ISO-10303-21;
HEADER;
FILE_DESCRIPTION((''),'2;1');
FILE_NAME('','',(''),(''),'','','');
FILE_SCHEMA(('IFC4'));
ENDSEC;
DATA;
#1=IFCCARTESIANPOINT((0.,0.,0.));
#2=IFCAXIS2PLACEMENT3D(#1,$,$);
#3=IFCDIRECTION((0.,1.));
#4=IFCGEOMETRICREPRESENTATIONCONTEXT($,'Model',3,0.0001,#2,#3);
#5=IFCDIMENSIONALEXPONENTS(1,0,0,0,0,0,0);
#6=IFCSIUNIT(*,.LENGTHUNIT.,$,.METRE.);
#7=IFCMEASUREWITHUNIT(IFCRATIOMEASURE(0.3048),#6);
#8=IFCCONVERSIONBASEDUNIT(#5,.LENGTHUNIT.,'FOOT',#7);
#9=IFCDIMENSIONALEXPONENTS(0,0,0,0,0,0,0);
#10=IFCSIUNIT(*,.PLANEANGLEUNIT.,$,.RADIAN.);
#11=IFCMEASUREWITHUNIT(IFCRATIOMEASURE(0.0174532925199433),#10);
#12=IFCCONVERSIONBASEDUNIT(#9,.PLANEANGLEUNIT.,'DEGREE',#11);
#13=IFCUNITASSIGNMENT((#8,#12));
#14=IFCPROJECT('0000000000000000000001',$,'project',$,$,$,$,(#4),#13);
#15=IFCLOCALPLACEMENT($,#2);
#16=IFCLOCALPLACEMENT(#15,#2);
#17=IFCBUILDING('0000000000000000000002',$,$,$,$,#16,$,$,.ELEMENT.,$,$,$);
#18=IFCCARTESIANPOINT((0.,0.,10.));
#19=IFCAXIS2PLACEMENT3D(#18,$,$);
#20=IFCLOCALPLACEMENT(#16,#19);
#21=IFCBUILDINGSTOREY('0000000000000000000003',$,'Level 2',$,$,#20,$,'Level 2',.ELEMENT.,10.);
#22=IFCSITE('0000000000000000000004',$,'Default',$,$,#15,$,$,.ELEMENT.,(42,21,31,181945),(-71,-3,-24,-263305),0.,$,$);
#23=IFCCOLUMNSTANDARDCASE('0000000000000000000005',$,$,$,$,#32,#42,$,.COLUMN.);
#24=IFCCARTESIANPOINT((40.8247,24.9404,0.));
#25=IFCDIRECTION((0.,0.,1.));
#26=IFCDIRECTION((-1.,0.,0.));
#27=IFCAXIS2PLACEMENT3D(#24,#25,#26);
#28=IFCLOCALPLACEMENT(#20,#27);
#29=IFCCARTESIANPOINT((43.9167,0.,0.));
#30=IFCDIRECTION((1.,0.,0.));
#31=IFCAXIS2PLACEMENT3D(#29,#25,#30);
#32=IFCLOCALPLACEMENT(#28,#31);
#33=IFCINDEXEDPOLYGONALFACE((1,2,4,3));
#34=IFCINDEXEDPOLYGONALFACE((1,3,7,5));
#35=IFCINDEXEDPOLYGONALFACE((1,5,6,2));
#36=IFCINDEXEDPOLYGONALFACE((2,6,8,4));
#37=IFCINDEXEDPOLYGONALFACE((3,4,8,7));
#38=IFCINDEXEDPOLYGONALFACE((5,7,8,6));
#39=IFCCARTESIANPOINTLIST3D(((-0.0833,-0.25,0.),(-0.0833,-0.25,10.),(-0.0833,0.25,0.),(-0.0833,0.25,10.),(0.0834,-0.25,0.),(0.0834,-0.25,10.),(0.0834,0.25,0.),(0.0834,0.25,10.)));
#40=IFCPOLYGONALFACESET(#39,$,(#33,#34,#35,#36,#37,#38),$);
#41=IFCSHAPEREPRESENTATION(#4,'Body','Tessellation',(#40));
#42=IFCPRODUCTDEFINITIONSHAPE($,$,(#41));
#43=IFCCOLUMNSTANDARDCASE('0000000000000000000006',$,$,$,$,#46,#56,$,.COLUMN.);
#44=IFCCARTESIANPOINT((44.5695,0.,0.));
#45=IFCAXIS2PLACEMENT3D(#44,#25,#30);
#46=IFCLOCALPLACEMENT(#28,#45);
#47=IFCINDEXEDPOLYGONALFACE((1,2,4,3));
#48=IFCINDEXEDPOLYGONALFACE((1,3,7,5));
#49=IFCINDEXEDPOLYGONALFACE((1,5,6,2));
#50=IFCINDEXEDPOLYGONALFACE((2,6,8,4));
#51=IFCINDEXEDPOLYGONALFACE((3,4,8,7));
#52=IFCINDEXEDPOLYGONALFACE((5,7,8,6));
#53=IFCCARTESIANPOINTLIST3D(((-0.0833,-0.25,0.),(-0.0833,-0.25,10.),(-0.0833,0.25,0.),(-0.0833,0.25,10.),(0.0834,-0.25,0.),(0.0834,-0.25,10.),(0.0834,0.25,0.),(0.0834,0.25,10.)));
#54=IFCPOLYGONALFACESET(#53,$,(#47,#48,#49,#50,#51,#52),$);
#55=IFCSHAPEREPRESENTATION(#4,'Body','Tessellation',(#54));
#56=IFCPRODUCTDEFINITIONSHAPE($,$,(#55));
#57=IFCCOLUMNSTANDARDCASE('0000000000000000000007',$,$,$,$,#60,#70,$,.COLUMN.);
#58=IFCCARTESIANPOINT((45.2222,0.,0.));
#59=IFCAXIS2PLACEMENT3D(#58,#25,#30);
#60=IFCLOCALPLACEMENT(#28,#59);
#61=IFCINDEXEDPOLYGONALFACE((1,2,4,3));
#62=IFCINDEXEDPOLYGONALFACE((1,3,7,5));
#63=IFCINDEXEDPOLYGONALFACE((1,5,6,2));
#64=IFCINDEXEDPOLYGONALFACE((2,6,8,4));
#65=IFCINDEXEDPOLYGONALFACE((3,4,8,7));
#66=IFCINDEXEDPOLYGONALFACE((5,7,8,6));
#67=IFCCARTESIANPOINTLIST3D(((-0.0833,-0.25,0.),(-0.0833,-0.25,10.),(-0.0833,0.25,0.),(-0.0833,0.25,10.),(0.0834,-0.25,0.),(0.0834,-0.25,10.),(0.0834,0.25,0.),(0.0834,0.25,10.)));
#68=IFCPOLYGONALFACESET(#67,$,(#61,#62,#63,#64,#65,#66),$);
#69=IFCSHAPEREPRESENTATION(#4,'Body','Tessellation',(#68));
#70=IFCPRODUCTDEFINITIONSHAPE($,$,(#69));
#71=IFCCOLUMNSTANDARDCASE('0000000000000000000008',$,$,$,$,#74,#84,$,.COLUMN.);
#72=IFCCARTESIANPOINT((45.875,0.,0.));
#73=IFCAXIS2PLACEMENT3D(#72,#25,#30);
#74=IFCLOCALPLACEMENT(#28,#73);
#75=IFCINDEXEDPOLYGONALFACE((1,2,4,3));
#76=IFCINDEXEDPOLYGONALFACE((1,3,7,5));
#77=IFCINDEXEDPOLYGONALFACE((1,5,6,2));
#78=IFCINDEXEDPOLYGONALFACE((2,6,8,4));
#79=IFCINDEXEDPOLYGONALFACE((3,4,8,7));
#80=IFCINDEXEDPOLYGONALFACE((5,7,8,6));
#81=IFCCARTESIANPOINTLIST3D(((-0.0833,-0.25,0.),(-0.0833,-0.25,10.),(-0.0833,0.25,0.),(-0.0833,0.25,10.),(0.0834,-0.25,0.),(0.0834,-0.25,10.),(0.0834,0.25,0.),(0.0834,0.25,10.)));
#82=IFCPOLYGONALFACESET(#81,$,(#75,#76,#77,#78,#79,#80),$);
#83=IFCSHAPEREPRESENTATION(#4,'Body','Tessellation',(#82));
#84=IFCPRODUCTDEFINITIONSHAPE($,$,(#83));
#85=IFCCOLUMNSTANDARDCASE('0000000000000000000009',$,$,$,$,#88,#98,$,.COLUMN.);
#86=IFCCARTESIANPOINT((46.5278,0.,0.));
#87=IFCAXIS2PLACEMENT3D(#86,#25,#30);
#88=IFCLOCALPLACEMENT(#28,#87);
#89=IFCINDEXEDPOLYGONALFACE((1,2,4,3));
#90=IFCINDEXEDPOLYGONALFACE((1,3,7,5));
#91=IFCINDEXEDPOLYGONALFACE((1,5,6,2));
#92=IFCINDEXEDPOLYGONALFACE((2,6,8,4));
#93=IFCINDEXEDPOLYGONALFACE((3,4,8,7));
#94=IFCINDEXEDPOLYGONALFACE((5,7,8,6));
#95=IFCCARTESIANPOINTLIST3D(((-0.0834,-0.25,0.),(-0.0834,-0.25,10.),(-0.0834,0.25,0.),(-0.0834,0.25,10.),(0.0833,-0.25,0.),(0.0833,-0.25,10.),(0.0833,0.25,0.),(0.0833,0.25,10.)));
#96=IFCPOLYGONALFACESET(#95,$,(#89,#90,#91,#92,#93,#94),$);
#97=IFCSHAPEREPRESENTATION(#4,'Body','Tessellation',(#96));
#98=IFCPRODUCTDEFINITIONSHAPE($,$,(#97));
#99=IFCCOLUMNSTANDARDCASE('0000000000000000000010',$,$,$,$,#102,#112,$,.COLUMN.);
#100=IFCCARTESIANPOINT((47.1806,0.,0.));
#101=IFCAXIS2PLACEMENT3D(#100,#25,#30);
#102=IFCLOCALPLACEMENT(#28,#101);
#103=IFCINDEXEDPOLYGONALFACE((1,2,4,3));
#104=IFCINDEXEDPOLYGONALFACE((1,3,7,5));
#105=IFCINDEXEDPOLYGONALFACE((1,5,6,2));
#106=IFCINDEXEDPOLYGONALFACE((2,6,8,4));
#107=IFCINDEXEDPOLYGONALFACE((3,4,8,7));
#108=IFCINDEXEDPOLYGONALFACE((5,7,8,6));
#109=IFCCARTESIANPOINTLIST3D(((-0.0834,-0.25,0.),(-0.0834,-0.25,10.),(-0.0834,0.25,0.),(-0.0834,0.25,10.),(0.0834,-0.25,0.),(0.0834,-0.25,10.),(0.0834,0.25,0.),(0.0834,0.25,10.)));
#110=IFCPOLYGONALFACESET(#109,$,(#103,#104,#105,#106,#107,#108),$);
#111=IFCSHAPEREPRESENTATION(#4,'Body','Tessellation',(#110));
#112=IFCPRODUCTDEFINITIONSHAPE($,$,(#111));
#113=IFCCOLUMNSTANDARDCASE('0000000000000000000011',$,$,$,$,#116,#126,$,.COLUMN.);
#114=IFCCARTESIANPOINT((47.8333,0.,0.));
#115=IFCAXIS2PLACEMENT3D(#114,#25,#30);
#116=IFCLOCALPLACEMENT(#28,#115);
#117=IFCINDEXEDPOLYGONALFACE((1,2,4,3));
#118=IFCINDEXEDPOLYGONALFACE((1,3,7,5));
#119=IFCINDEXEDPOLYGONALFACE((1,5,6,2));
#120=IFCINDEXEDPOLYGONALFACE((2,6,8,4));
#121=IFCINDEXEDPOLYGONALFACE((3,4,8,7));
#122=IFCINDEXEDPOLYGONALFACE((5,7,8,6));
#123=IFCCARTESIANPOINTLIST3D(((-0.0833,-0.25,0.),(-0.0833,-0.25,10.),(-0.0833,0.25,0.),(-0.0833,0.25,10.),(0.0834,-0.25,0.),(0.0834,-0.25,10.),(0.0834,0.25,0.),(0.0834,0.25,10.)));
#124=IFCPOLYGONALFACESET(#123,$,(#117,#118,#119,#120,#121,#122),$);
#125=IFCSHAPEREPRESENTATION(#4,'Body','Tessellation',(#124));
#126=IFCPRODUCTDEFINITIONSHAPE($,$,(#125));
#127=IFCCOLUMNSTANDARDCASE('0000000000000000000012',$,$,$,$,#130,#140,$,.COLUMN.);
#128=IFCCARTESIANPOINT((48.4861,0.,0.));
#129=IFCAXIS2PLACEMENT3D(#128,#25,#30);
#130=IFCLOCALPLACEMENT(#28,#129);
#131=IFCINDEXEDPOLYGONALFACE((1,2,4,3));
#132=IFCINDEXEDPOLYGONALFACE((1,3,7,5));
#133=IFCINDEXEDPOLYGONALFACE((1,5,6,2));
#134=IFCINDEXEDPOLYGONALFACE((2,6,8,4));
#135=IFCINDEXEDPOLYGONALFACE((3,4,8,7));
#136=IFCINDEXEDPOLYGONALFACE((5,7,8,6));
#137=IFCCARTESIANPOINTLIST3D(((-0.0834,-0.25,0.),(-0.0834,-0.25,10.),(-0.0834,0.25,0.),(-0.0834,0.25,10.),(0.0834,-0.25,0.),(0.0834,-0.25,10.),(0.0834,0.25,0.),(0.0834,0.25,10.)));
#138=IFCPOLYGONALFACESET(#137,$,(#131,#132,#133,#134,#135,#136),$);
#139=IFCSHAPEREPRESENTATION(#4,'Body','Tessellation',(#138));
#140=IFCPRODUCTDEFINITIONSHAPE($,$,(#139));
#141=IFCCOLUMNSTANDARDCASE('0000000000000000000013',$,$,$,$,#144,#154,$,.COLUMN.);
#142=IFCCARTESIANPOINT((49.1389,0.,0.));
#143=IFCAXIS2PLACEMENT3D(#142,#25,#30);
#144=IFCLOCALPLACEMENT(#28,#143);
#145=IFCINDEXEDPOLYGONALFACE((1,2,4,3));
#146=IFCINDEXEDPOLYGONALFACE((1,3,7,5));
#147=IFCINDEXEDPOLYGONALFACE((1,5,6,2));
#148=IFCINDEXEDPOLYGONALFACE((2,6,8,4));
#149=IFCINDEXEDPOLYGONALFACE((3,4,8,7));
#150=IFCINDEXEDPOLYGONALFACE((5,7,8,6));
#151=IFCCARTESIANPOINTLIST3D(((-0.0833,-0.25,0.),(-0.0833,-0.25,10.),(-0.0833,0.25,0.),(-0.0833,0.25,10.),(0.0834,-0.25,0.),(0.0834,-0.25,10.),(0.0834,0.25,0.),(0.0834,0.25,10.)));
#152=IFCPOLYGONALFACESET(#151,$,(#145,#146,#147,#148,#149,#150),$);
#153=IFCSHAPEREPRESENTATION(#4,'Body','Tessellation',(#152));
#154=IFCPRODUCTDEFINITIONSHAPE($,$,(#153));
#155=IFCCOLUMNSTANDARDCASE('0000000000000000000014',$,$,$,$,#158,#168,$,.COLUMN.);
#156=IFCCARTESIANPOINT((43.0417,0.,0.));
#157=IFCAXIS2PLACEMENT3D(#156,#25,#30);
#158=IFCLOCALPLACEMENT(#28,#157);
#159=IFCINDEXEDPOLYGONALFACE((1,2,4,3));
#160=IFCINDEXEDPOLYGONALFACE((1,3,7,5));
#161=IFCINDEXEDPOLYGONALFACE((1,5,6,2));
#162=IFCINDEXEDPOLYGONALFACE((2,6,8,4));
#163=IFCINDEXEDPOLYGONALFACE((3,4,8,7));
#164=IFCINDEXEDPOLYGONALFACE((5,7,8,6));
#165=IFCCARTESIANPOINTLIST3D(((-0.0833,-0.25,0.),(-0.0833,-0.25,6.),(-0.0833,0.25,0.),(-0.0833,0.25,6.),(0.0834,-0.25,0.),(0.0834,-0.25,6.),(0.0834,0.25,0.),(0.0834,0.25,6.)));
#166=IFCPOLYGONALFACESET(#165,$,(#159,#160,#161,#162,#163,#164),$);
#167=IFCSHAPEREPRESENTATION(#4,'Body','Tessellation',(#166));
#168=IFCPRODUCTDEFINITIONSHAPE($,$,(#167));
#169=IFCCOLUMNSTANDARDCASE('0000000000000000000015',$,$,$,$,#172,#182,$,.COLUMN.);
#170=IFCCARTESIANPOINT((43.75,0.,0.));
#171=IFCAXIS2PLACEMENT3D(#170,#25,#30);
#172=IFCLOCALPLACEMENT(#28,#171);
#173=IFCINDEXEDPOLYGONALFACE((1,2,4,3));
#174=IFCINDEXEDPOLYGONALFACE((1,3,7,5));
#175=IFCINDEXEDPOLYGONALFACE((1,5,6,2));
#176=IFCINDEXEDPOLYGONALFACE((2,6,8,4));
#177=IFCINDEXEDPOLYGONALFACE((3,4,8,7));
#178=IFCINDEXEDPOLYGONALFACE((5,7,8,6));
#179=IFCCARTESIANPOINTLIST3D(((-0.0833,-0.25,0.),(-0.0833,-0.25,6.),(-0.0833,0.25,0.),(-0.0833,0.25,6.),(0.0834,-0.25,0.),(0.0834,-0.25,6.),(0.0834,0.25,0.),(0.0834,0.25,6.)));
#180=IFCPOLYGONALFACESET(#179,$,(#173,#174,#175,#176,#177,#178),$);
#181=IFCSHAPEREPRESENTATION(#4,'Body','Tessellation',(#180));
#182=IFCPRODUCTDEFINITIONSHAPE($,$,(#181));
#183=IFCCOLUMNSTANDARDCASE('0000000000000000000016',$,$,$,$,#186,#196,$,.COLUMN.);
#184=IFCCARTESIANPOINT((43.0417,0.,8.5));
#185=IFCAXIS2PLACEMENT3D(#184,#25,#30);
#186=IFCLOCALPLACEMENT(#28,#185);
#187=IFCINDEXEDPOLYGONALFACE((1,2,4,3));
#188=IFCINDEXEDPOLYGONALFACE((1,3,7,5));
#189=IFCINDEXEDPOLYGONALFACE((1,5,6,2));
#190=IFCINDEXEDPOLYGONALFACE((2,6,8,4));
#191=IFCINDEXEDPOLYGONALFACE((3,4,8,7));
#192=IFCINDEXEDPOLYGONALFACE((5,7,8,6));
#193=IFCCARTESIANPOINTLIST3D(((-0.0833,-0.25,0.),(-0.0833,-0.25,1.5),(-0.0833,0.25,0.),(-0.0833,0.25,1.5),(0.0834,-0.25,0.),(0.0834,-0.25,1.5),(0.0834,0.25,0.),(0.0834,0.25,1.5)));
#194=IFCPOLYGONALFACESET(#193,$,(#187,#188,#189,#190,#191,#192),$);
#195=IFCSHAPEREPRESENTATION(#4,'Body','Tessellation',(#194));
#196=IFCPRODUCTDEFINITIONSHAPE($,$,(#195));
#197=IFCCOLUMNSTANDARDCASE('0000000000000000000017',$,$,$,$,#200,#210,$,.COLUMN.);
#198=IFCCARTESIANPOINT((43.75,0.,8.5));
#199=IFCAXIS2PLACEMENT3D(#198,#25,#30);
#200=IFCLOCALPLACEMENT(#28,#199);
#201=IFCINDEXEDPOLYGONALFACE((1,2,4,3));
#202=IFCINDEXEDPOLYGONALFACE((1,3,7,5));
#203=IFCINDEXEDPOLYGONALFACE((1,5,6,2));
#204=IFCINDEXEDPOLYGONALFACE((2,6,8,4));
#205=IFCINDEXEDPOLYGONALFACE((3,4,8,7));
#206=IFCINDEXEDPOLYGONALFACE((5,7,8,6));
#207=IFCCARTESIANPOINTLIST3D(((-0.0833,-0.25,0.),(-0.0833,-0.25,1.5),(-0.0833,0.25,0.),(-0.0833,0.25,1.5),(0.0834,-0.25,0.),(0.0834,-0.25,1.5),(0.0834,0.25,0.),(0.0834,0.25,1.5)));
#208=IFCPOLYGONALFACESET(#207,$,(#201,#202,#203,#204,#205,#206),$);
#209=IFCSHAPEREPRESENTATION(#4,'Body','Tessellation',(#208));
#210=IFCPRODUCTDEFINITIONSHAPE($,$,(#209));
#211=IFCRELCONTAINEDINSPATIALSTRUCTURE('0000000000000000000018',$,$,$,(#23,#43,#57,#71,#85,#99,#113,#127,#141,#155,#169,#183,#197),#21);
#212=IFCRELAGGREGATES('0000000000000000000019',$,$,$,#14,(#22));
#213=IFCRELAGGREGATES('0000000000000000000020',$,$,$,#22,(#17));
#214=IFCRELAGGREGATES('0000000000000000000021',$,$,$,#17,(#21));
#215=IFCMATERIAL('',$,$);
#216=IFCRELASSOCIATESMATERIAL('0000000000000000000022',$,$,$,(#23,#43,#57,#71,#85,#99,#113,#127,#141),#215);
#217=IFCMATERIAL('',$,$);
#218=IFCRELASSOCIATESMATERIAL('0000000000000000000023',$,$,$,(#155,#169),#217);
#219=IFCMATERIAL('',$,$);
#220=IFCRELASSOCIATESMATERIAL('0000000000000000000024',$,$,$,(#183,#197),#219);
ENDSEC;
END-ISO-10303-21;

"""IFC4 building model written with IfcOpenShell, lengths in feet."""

from ifc_helpers import new_model, entity, si_unit, converted_unit, direction, frame, origin, place, context, project, spatial, rectangle, extrude, material, element, save


model = new_model("IFC4")

# Units and contexts
model_context = context("Model", 3, precision=0.0001, world=origin(), true_north=direction((0.0, 1.0)))
ifc_project = project(units=[converted_unit("LENGTHUNIT", "FOOT", entity("IfcRatioMeasure", 0.3048), si_unit("LENGTHUNIT", "METRE"), dimensions=[1, 0, 0, 0, 0, 0, 0]), converted_unit("PLANEANGLEUNIT", "DEGREE", entity("IfcRatioMeasure", 0.0174532925199433), si_unit("PLANEANGLEUNIT", "RADIAN"), dimensions=[0, 0, 0, 0, 0, 0, 0])], contexts=[model_context])

# Site, building, storey
site_placement = place(None, origin())
site = spatial("IfcSite", under=ifc_project, at=site_placement, Name="Default", CompositionType="ELEMENT", RefLatitude=(42, 21, 31, 181945), RefLongitude=(-71, -3, -24, -263305), RefElevation=0.0)
building_placement = place(site_placement, origin())
building = spatial("IfcBuilding", under=site, at=building_placement, CompositionType="ELEMENT")
storey_placement = place(building_placement, frame((0.0, 0.0, 10.0)))
storey = spatial("IfcBuildingStorey", under=building, at=storey_placement, Name="Level 2", LongName="Level 2", CompositionType="ELEMENT", Elevation=10.0)

# Columns
ifc_material_1 = material(Name="")
placement = place(storey_placement, frame((40.8247, 24.9404, 0.0), z_axis=(0.0, 0.0, 1.0), x_axis=(-1.0, 0.0, 0.0)))
for number, where, z_axis, x_axis in (
    (1, (43.9167, 0.0, 0.0), (0.0, 0.0, 1.0), (1.0, 0.0, 0.0)),
    (2, (44.5695, 0.0, 0.0), (0.0, 0.0, 1.0), (1.0, 0.0, 0.0)),
    (3, (45.2222, 0.0, 0.0), (0.0, 0.0, 1.0), (1.0, 0.0, 0.0)),
    (4, (45.875, 0.0, 0.0), (0.0, 0.0, 1.0), (1.0, 0.0, 0.0)),
    (5, (46.5278, 0.0, 0.0), (0.0, 0.0, 1.0), (1.0, 0.0, 0.0)),
    (6, (47.1806, 0.0, 0.0), (0.0, 0.0, 1.0), (1.0, 0.0, 0.0)),
    (7, (47.8333, 0.0, 0.0), (0.0, 0.0, 1.0), (1.0, 0.0, 0.0)),
    (8, (48.4861, 0.0, 0.0), (0.0, 0.0, 1.0), (1.0, 0.0, 0.0)),
    (9, (49.1389, 0.0, 0.0), (0.0, 0.0, 1.0), (1.0, 0.0, 0.0)),
):
    element("IfcColumnStandardCase", number, at=place(placement, frame(where, z_axis=z_axis, x_axis=x_axis)), inside=storey, material=ifc_material_1, PredefinedType="COLUMN", context=model_context, shape_type="SweptSolid", body=[
        extrude(rectangle(XDim=0.1667, YDim=0.5), origin(), (0.0, 0.0, 1.0), 10.0),
    ])
ifc_material_2 = material(Name="")
for number, where, z_axis, x_axis in (
    (10, (43.0417, 0.0, 0.0), (0.0, 0.0, 1.0), (1.0, 0.0, 0.0)),
    (11, (43.75, 0.0, 0.0), (0.0, 0.0, 1.0), (1.0, 0.0, 0.0)),
):
    element("IfcColumnStandardCase", number, at=place(placement, frame(where, z_axis=z_axis, x_axis=x_axis)), inside=storey, material=ifc_material_2, PredefinedType="COLUMN", context=model_context, shape_type="SweptSolid", body=[
        extrude(rectangle(XDim=0.1667, YDim=0.5), origin(), (0.0, 0.0, 1.0), 6.0),
    ])
ifc_material_3 = material(Name="")
for number, where, z_axis, x_axis in (
    (12, (43.0417, 0.0, 8.5), (0.0, 0.0, 1.0), (1.0, 0.0, 0.0)),
    (13, (43.75, 0.0, 8.5), (0.0, 0.0, 1.0), (1.0, 0.0, 0.0)),
):
    element("IfcColumnStandardCase", number, at=place(placement, frame(where, z_axis=z_axis, x_axis=x_axis)), inside=storey, material=ifc_material_3, PredefinedType="COLUMN", context=model_context, shape_type="SweptSolid", body=[
        extrude(rectangle(XDim=0.1667, YDim=0.5), origin(), (0.0, 0.0, 1.0), 1.5),
    ])

save(model, "model.ifc")
